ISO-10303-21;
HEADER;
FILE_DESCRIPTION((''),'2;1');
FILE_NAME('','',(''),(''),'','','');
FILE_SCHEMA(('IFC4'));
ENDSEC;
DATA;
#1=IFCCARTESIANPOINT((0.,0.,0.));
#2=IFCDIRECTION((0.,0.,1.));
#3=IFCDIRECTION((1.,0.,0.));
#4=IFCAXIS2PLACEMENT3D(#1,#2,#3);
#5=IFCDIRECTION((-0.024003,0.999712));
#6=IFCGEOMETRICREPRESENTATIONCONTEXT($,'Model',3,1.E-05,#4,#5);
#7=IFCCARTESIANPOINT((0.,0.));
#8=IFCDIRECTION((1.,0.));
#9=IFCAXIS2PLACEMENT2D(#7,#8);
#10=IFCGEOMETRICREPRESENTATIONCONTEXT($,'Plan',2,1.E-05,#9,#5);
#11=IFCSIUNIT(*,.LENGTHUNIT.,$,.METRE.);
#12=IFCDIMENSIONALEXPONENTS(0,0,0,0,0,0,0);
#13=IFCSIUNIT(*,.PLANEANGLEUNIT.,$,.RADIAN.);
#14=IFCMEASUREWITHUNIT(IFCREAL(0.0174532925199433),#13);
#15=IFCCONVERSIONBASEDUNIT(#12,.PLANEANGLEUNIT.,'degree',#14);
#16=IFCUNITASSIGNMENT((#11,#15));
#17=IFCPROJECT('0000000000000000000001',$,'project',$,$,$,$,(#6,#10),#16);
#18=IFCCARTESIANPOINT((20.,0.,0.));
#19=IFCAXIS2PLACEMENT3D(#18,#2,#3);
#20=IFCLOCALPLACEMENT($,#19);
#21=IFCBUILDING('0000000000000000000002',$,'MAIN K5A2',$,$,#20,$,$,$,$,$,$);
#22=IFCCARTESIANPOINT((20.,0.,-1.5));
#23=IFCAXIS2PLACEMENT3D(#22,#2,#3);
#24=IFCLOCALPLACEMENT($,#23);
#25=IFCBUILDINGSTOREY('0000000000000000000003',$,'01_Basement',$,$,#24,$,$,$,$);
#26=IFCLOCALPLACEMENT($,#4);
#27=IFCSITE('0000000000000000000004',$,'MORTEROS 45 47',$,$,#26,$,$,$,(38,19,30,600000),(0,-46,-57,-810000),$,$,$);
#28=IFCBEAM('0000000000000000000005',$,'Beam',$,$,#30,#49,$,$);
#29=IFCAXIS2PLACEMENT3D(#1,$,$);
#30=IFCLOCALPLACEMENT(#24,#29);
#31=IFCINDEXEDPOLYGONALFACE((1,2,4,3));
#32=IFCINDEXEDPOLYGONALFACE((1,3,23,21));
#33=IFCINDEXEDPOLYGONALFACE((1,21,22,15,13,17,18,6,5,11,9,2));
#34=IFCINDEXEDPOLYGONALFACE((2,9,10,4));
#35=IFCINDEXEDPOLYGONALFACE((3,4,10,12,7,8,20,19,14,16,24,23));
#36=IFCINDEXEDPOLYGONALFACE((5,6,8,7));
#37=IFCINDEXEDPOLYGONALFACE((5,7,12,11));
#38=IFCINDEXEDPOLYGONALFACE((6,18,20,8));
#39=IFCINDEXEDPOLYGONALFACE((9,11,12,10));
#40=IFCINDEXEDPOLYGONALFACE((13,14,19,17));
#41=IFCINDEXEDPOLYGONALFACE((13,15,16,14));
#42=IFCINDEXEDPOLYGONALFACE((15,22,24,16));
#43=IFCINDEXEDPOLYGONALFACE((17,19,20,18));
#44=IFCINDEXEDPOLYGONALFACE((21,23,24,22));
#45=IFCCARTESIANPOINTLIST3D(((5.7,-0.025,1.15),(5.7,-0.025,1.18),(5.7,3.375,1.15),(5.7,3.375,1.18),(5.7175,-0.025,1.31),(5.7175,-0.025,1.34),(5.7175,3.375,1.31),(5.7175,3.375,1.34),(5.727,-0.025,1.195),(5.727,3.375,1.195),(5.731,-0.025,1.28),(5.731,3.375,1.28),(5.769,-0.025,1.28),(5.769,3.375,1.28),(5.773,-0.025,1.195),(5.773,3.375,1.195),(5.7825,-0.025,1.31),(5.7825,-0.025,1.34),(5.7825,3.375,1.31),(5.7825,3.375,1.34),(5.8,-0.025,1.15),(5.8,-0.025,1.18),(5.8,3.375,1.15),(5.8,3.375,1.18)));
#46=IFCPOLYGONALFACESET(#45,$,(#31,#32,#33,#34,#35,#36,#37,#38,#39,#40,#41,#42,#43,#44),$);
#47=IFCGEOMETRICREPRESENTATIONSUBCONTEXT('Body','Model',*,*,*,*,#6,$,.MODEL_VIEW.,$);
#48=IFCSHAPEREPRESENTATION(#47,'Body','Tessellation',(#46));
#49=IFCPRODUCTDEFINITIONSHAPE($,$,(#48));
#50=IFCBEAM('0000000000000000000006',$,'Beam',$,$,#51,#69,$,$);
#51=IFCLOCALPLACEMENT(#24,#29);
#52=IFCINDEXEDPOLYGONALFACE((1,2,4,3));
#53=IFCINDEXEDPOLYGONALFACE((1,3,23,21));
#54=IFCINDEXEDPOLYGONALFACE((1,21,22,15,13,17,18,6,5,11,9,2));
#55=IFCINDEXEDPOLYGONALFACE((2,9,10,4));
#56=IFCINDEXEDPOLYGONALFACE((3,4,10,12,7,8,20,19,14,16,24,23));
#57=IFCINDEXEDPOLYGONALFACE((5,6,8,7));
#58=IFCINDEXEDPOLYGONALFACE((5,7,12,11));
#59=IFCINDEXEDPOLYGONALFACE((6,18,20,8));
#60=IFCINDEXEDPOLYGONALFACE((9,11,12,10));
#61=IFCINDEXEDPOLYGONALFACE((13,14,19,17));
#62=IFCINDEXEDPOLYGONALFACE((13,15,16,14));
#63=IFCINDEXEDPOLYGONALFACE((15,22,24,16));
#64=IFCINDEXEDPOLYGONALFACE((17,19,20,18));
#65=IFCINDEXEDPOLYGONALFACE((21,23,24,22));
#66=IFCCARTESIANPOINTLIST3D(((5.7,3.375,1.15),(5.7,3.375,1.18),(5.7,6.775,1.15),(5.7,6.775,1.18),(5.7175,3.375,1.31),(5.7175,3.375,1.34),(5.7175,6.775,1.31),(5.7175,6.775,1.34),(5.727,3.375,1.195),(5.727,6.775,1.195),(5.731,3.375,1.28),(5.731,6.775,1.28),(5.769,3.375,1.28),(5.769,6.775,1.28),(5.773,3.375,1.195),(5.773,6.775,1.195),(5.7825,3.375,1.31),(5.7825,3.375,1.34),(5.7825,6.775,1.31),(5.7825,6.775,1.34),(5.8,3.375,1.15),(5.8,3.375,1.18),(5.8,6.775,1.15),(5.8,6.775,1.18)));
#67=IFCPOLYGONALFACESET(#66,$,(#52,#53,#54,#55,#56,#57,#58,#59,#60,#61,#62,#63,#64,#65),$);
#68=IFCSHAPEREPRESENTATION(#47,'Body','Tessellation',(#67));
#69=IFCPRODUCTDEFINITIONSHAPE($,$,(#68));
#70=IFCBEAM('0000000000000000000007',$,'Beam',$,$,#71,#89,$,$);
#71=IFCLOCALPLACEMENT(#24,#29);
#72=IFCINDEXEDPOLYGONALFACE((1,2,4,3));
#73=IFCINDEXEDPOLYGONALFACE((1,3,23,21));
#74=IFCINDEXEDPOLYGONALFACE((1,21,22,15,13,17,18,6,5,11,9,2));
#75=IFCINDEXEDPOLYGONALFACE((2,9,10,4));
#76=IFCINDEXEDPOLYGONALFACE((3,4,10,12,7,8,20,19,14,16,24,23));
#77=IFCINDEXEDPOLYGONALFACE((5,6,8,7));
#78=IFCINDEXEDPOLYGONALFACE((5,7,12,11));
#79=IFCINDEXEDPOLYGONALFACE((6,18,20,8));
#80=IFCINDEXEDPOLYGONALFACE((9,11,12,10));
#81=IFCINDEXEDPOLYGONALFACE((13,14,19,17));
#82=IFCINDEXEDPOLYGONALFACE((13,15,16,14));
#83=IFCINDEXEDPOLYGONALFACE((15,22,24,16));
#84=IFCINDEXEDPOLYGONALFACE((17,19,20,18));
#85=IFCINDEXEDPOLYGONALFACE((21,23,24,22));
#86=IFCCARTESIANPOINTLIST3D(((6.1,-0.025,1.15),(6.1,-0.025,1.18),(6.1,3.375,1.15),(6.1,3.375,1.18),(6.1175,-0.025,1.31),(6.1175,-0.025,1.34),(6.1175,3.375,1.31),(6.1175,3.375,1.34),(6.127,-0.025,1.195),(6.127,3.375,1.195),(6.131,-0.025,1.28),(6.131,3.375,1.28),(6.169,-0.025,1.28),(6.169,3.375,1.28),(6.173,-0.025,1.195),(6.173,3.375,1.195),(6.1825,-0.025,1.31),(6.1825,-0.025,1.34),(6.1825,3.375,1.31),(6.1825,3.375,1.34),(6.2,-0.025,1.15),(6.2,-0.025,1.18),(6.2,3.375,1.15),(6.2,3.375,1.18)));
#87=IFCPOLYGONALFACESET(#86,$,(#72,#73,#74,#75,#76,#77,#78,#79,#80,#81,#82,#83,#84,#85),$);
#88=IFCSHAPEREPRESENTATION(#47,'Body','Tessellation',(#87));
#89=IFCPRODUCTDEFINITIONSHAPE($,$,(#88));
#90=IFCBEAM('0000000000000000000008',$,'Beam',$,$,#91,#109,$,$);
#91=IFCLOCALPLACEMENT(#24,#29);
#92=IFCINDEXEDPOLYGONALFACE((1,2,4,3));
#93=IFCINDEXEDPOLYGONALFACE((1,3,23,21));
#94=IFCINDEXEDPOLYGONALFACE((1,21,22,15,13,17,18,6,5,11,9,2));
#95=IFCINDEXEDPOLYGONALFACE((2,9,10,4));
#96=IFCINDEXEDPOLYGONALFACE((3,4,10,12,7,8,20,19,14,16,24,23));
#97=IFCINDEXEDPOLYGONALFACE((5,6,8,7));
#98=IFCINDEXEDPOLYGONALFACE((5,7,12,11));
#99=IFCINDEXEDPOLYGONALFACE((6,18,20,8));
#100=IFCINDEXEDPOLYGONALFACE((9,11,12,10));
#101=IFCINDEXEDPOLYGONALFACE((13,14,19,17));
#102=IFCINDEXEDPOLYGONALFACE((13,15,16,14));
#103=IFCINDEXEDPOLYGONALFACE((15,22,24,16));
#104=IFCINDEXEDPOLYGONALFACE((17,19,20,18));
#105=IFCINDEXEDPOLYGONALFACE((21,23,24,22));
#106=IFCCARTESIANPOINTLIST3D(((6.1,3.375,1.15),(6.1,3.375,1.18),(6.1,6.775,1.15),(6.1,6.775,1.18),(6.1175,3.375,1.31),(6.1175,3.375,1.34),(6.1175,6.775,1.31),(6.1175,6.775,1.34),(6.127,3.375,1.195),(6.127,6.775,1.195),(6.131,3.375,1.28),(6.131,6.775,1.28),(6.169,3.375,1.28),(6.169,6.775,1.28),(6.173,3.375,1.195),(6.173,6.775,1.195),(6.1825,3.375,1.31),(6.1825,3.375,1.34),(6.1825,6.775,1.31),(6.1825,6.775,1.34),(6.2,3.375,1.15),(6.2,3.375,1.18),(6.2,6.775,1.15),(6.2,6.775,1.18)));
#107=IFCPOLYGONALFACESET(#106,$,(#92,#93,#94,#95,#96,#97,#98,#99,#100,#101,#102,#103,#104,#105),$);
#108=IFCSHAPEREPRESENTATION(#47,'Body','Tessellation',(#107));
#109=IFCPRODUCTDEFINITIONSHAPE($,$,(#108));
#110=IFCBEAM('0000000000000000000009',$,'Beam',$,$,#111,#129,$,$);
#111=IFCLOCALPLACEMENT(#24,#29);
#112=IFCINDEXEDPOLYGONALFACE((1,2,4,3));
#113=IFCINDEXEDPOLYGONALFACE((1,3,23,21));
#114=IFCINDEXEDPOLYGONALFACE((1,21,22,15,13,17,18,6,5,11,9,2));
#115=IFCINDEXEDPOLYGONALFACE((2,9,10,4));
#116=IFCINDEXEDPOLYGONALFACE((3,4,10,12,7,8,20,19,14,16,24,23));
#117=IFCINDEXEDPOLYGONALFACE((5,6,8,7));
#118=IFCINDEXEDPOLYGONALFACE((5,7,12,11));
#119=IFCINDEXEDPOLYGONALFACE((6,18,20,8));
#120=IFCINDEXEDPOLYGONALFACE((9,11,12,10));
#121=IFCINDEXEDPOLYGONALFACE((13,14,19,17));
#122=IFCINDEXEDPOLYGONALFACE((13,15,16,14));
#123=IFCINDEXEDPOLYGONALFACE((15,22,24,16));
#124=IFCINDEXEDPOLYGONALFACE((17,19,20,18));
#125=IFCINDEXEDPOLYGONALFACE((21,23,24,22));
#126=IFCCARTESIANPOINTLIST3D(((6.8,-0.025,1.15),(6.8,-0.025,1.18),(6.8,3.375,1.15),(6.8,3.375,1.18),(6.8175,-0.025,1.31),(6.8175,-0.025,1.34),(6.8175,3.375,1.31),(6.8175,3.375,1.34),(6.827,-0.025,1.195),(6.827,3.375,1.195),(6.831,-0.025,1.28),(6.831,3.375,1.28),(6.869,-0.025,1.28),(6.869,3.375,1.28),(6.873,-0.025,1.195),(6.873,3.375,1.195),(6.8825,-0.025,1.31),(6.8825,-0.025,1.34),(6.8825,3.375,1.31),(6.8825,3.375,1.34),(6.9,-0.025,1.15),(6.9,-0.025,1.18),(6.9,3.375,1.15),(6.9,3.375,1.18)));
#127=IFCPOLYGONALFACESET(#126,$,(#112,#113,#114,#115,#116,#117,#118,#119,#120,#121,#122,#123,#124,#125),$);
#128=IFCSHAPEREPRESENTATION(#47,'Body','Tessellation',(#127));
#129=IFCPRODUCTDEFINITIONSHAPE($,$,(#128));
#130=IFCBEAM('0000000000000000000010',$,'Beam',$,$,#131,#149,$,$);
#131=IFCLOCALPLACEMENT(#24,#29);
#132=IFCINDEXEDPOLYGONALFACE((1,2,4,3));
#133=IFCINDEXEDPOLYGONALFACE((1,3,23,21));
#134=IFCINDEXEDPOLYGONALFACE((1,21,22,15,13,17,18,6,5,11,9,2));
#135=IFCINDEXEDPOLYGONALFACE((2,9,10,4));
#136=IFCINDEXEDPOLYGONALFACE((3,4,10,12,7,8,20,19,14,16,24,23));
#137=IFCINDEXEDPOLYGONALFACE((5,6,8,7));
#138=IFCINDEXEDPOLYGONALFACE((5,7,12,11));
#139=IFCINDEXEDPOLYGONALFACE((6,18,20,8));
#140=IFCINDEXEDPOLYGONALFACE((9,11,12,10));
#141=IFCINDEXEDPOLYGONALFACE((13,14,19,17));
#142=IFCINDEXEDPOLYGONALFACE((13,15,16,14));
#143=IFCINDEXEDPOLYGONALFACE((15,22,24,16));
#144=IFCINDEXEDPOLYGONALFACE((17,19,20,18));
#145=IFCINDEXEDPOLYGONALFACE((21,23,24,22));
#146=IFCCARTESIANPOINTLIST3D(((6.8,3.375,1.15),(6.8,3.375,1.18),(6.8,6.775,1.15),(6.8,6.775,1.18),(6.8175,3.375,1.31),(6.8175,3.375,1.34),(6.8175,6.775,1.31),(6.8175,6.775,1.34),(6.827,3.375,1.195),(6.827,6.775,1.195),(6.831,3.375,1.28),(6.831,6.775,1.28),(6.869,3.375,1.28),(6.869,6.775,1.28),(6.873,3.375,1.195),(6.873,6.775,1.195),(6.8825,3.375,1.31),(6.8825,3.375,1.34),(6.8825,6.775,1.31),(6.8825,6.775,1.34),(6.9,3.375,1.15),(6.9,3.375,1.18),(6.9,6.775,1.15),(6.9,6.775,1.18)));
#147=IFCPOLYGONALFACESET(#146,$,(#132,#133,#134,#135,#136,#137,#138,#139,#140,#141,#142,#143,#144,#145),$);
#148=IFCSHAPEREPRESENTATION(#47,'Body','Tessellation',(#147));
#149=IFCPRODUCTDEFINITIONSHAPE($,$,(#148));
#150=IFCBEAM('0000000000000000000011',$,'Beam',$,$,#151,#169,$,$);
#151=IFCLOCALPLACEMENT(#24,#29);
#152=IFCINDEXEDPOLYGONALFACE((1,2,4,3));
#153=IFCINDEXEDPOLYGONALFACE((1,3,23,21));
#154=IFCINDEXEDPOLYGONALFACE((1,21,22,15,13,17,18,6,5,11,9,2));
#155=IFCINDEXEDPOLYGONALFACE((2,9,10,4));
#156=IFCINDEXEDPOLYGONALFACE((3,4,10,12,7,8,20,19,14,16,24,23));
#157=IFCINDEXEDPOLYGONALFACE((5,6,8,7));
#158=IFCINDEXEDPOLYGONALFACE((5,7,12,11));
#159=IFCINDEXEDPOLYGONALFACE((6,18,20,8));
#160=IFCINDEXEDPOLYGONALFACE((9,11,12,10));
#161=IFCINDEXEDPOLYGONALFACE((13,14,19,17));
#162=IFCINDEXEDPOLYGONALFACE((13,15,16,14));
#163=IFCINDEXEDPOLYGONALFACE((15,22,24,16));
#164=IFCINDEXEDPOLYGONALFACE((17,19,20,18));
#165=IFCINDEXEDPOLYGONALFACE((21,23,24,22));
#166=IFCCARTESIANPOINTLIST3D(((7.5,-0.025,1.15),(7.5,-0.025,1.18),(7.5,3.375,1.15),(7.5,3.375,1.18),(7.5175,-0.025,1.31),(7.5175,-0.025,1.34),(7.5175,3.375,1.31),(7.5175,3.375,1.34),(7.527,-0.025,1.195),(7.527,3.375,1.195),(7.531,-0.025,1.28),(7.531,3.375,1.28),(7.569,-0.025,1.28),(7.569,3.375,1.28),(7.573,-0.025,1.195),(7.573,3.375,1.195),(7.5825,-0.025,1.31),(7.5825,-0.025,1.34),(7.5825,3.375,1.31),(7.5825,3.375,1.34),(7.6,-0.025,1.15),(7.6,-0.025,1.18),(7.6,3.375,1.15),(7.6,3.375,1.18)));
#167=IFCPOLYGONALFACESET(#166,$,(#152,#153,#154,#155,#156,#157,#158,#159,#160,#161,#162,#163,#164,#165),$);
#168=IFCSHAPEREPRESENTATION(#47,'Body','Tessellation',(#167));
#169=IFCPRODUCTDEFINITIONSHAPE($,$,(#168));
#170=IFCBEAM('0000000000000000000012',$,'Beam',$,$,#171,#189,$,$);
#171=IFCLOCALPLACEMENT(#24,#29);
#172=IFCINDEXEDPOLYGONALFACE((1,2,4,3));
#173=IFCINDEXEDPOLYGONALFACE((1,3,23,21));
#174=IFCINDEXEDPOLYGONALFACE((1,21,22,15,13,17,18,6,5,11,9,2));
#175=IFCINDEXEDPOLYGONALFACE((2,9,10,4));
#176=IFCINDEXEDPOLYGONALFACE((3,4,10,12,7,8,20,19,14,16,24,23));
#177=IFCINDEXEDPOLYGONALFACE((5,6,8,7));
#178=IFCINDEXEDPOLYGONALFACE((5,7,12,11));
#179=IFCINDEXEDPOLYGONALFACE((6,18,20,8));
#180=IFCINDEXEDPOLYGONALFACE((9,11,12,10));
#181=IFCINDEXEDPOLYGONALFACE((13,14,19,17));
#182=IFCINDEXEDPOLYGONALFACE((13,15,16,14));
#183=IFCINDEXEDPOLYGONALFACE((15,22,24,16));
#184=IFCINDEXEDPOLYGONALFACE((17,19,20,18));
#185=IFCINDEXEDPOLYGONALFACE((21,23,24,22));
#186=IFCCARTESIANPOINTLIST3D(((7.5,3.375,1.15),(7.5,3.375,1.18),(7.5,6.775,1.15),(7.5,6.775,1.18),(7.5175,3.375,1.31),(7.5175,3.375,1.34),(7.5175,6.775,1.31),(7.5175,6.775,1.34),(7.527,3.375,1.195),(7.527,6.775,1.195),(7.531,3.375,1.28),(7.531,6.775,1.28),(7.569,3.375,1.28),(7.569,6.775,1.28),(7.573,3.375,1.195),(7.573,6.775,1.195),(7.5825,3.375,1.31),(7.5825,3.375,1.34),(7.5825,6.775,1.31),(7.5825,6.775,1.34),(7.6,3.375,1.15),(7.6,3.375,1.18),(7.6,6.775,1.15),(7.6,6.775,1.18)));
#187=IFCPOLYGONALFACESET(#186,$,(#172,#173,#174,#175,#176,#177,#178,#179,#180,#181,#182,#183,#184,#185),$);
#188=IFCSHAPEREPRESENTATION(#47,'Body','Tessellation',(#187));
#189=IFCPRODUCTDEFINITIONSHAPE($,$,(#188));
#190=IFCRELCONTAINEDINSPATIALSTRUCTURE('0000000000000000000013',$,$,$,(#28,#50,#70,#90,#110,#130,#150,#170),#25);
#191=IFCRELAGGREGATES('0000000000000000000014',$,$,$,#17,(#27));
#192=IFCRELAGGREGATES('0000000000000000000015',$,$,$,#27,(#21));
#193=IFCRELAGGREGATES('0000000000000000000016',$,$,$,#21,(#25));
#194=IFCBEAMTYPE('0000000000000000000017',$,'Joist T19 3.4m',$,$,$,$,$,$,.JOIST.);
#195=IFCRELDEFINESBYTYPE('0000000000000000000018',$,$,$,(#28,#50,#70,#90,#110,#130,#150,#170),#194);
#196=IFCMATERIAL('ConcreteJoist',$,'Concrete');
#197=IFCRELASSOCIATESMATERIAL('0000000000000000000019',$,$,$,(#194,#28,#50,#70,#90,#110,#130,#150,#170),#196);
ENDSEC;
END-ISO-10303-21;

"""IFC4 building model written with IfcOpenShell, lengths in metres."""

from ifc_helpers import new_model, entity, si_unit, converted_unit, direction, frame, origin_with_axes, origin_2d_with_axis, place, context, subcontext, project, spatial, indexed_curve, outline, extrude, material, material_profile, profile_set, profile_usage, type_object, element, save


model = new_model("IFC4")

# Units and contexts
model_context = context("Model", 3, precision=1e-05, world=origin_with_axes(), true_north=direction((-0.024003, 0.999712)))
plan_context = context("Plan", 2, precision=1e-05, world=origin_2d_with_axis(), true_north=direction((-0.024003, 0.999712)))
body_context = subcontext(model_context, "Body", "Model", "MODEL_VIEW")
ifc_project = project(units=[si_unit("LENGTHUNIT", "METRE"), converted_unit("PLANEANGLEUNIT", "degree", entity("IfcReal", 0.0174532925199433), si_unit("PLANEANGLEUNIT", "RADIAN"), dimensions=[0, 0, 0, 0, 0, 0, 0])], contexts=[model_context, plan_context])

# Site, building, storey
site_placement = place(None, origin_with_axes())
site = spatial("IfcSite", under=ifc_project, at=site_placement, Name="MORTEROS 45 47", RefLatitude=(38, 19, 30, 600000), RefLongitude=(0, -46, -57, -810000))
building_placement = place(None, frame((20.0, 0.0, 0.0), z_axis=(0.0, 0.0, 1.0), x_axis=(1.0, 0.0, 0.0)))
building = spatial("IfcBuilding", under=site, at=building_placement, Name="MAIN K5A2")
storey_placement = place(None, frame((20.0, 0.0, -1.5), z_axis=(0.0, 0.0, 1.0), x_axis=(1.0, 0.0, 0.0)))
storey = spatial("IfcBuildingStorey", under=building, at=storey_placement, Name="01_Basement")

# Beams
ifc_material = material(Name="ConcreteJoist", Category="Concrete")
ifc_material_profile = material_profile(ifc_material, outline(indexed_curve([(0.019, 0.13), (0.023, 0.045), (0.05, 0.03), (0.05, 0.0), (-0.05, 0.0), (-0.05, 0.03), (-0.023, 0.045), (-0.019, 0.13), (-0.0325, 0.16), (-0.0325, 0.19), (0.0325, 0.19), (0.0325, 0.16), (0.019, 0.13)])))
ifc_profile_set = profile_set([ifc_material_profile], Name="JoistMaterialProfileSet")
beam_type = type_object("IfcBeamType", Name="Joist T19 3.4m", PredefinedType="JOIST", material=ifc_profile_set)
ifc_profile_usage_1 = profile_usage(ifc_profile_set, cardinal=5)
beam_1_placement = place(None, frame((25.75, -0.025, -0.35), z_axis=(0.0, 1.0, 0.0), x_axis=(-1.0, 0.0, 0.0)))
element("IfcBeam", 1, at=beam_1_placement, inside=storey, type_object=beam_type, material=ifc_profile_usage_1, Name="Beam", context=body_context, shape_type="SweptSolid", body=[
    extrude(outline(indexed_curve([(0.019, 0.13), (0.023, 0.045), (0.05, 0.03), (0.05, 0.0), (-0.05, 0.0), (-0.05, 0.03), (-0.023, 0.045), (-0.019, 0.13), (-0.0325, 0.16), (-0.0325, 0.19), (0.0325, 0.19), (0.0325, 0.16), (0.019, 0.13)])), origin_with_axes(), (0.0, 0.0, 1.0), 3.4),
])
ifc_profile_usage_2 = profile_usage(ifc_profile_set, cardinal=5)
beam_2_placement = place(None, frame((25.75, 3.375, -0.35), z_axis=(0.0, 1.0, 0.0), x_axis=(-1.0, 0.0, 0.0)))
element("IfcBeam", 2, at=beam_2_placement, inside=storey, type_object=beam_type, material=ifc_profile_usage_2, Name="Beam", context=body_context, shape_type="SweptSolid", body=[
    extrude(outline(indexed_curve([(0.019, 0.13), (0.023, 0.045), (0.05, 0.03), (0.05, 0.0), (-0.05, 0.0), (-0.05, 0.03), (-0.023, 0.045), (-0.019, 0.13), (-0.0325, 0.16), (-0.0325, 0.19), (0.0325, 0.19), (0.0325, 0.16), (0.019, 0.13)])), origin_with_axes(), (0.0, 0.0, 1.0), 3.4),
])
ifc_profile_usage_3 = profile_usage(ifc_profile_set, cardinal=5)
beam_3_placement = place(None, frame((26.15, -0.025, -0.35), z_axis=(0.0, 1.0, 0.0), x_axis=(-1.0, 0.0, 0.0)))
element("IfcBeam", 3, at=beam_3_placement, inside=storey, type_object=beam_type, material=ifc_profile_usage_3, Name="Beam", context=body_context, shape_type="SweptSolid", body=[
    extrude(outline(indexed_curve([(0.019, 0.13), (0.023, 0.045), (0.05, 0.03), (0.05, 0.0), (-0.05, 0.0), (-0.05, 0.03), (-0.023, 0.045), (-0.019, 0.13), (-0.0325, 0.16), (-0.0325, 0.19), (0.0325, 0.19), (0.0325, 0.16), (0.019, 0.13)])), origin_with_axes(), (0.0, 0.0, 1.0), 3.4),
])
ifc_profile_usage_4 = profile_usage(ifc_profile_set, cardinal=5)
beam_4_placement = place(None, frame((26.15, 3.375, -0.35), z_axis=(0.0, 1.0, 0.0), x_axis=(-1.0, 0.0, 0.0)))
element("IfcBeam", 4, at=beam_4_placement, inside=storey, type_object=beam_type, material=ifc_profile_usage_4, Name="Beam", context=body_context, shape_type="SweptSolid", body=[
    extrude(outline(indexed_curve([(0.019, 0.13), (0.023, 0.045), (0.05, 0.03), (0.05, 0.0), (-0.05, 0.0), (-0.05, 0.03), (-0.023, 0.045), (-0.019, 0.13), (-0.0325, 0.16), (-0.0325, 0.19), (0.0325, 0.19), (0.0325, 0.16), (0.019, 0.13)])), origin_with_axes(), (0.0, 0.0, 1.0), 3.4),
])
ifc_profile_usage_5 = profile_usage(ifc_profile_set, cardinal=5)
beam_5_placement = place(None, frame((26.85, -0.025, -0.35), z_axis=(0.0, 1.0, 0.0), x_axis=(-1.0, 0.0, 0.0)))
element("IfcBeam", 5, at=beam_5_placement, inside=storey, type_object=beam_type, material=ifc_profile_usage_5, Name="Beam", context=body_context, shape_type="SweptSolid", body=[
    extrude(outline(indexed_curve([(0.019, 0.13), (0.023, 0.045), (0.05, 0.03), (0.05, 0.0), (-0.05, 0.0), (-0.05, 0.03), (-0.023, 0.045), (-0.019, 0.13), (-0.0325, 0.16), (-0.0325, 0.19), (0.0325, 0.19), (0.0325, 0.16), (0.019, 0.13)])), origin_with_axes(), (0.0, 0.0, 1.0), 3.4),
])
ifc_profile_usage_6 = profile_usage(ifc_profile_set, cardinal=5)
beam_6_placement = place(None, frame((26.85, 3.375, -0.35), z_axis=(0.0, 1.0, 0.0), x_axis=(-1.0, 0.0, 0.0)))
element("IfcBeam", 6, at=beam_6_placement, inside=storey, type_object=beam_type, material=ifc_profile_usage_6, Name="Beam", context=body_context, shape_type="SweptSolid", body=[
    extrude(outline(indexed_curve([(0.019, 0.13), (0.023, 0.045), (0.05, 0.03), (0.05, 0.0), (-0.05, 0.0), (-0.05, 0.03), (-0.023, 0.045), (-0.019, 0.13), (-0.0325, 0.16), (-0.0325, 0.19), (0.0325, 0.19), (0.0325, 0.16), (0.019, 0.13)])), origin_with_axes(), (0.0, 0.0, 1.0), 3.4),
])
ifc_profile_usage_7 = profile_usage(ifc_profile_set, cardinal=5)
beam_7_placement = place(None, frame((27.55, -0.025, -0.35), z_axis=(0.0, 1.0, 0.0), x_axis=(-1.0, 0.0, 0.0)))
element("IfcBeam", 7, at=beam_7_placement, inside=storey, type_object=beam_type, material=ifc_profile_usage_7, Name="Beam", context=body_context, shape_type="SweptSolid", body=[
    extrude(outline(indexed_curve([(0.019, 0.13), (0.023, 0.045), (0.05, 0.03), (0.05, 0.0), (-0.05, 0.0), (-0.05, 0.03), (-0.023, 0.045), (-0.019, 0.13), (-0.0325, 0.16), (-0.0325, 0.19), (0.0325, 0.19), (0.0325, 0.16), (0.019, 0.13)])), origin_with_axes(), (0.0, 0.0, 1.0), 3.4),
])
ifc_profile_usage_8 = profile_usage(ifc_profile_set, cardinal=5)
beam_8_placement = place(None, frame((27.55, 3.375, -0.35), z_axis=(0.0, 1.0, 0.0), x_axis=(-1.0, 0.0, 0.0)))
element("IfcBeam", 8, at=beam_8_placement, inside=storey, type_object=beam_type, material=ifc_profile_usage_8, Name="Beam", context=body_context, shape_type="SweptSolid", body=[
    extrude(outline(indexed_curve([(0.019, 0.13), (0.023, 0.045), (0.05, 0.03), (0.05, 0.0), (-0.05, 0.0), (-0.05, 0.03), (-0.023, 0.045), (-0.019, 0.13), (-0.0325, 0.16), (-0.0325, 0.19), (0.0325, 0.19), (0.0325, 0.16), (0.019, 0.13)])), origin_with_axes(), (0.0, 0.0, 1.0), 3.4),
])

save(model, "model.ifc")
